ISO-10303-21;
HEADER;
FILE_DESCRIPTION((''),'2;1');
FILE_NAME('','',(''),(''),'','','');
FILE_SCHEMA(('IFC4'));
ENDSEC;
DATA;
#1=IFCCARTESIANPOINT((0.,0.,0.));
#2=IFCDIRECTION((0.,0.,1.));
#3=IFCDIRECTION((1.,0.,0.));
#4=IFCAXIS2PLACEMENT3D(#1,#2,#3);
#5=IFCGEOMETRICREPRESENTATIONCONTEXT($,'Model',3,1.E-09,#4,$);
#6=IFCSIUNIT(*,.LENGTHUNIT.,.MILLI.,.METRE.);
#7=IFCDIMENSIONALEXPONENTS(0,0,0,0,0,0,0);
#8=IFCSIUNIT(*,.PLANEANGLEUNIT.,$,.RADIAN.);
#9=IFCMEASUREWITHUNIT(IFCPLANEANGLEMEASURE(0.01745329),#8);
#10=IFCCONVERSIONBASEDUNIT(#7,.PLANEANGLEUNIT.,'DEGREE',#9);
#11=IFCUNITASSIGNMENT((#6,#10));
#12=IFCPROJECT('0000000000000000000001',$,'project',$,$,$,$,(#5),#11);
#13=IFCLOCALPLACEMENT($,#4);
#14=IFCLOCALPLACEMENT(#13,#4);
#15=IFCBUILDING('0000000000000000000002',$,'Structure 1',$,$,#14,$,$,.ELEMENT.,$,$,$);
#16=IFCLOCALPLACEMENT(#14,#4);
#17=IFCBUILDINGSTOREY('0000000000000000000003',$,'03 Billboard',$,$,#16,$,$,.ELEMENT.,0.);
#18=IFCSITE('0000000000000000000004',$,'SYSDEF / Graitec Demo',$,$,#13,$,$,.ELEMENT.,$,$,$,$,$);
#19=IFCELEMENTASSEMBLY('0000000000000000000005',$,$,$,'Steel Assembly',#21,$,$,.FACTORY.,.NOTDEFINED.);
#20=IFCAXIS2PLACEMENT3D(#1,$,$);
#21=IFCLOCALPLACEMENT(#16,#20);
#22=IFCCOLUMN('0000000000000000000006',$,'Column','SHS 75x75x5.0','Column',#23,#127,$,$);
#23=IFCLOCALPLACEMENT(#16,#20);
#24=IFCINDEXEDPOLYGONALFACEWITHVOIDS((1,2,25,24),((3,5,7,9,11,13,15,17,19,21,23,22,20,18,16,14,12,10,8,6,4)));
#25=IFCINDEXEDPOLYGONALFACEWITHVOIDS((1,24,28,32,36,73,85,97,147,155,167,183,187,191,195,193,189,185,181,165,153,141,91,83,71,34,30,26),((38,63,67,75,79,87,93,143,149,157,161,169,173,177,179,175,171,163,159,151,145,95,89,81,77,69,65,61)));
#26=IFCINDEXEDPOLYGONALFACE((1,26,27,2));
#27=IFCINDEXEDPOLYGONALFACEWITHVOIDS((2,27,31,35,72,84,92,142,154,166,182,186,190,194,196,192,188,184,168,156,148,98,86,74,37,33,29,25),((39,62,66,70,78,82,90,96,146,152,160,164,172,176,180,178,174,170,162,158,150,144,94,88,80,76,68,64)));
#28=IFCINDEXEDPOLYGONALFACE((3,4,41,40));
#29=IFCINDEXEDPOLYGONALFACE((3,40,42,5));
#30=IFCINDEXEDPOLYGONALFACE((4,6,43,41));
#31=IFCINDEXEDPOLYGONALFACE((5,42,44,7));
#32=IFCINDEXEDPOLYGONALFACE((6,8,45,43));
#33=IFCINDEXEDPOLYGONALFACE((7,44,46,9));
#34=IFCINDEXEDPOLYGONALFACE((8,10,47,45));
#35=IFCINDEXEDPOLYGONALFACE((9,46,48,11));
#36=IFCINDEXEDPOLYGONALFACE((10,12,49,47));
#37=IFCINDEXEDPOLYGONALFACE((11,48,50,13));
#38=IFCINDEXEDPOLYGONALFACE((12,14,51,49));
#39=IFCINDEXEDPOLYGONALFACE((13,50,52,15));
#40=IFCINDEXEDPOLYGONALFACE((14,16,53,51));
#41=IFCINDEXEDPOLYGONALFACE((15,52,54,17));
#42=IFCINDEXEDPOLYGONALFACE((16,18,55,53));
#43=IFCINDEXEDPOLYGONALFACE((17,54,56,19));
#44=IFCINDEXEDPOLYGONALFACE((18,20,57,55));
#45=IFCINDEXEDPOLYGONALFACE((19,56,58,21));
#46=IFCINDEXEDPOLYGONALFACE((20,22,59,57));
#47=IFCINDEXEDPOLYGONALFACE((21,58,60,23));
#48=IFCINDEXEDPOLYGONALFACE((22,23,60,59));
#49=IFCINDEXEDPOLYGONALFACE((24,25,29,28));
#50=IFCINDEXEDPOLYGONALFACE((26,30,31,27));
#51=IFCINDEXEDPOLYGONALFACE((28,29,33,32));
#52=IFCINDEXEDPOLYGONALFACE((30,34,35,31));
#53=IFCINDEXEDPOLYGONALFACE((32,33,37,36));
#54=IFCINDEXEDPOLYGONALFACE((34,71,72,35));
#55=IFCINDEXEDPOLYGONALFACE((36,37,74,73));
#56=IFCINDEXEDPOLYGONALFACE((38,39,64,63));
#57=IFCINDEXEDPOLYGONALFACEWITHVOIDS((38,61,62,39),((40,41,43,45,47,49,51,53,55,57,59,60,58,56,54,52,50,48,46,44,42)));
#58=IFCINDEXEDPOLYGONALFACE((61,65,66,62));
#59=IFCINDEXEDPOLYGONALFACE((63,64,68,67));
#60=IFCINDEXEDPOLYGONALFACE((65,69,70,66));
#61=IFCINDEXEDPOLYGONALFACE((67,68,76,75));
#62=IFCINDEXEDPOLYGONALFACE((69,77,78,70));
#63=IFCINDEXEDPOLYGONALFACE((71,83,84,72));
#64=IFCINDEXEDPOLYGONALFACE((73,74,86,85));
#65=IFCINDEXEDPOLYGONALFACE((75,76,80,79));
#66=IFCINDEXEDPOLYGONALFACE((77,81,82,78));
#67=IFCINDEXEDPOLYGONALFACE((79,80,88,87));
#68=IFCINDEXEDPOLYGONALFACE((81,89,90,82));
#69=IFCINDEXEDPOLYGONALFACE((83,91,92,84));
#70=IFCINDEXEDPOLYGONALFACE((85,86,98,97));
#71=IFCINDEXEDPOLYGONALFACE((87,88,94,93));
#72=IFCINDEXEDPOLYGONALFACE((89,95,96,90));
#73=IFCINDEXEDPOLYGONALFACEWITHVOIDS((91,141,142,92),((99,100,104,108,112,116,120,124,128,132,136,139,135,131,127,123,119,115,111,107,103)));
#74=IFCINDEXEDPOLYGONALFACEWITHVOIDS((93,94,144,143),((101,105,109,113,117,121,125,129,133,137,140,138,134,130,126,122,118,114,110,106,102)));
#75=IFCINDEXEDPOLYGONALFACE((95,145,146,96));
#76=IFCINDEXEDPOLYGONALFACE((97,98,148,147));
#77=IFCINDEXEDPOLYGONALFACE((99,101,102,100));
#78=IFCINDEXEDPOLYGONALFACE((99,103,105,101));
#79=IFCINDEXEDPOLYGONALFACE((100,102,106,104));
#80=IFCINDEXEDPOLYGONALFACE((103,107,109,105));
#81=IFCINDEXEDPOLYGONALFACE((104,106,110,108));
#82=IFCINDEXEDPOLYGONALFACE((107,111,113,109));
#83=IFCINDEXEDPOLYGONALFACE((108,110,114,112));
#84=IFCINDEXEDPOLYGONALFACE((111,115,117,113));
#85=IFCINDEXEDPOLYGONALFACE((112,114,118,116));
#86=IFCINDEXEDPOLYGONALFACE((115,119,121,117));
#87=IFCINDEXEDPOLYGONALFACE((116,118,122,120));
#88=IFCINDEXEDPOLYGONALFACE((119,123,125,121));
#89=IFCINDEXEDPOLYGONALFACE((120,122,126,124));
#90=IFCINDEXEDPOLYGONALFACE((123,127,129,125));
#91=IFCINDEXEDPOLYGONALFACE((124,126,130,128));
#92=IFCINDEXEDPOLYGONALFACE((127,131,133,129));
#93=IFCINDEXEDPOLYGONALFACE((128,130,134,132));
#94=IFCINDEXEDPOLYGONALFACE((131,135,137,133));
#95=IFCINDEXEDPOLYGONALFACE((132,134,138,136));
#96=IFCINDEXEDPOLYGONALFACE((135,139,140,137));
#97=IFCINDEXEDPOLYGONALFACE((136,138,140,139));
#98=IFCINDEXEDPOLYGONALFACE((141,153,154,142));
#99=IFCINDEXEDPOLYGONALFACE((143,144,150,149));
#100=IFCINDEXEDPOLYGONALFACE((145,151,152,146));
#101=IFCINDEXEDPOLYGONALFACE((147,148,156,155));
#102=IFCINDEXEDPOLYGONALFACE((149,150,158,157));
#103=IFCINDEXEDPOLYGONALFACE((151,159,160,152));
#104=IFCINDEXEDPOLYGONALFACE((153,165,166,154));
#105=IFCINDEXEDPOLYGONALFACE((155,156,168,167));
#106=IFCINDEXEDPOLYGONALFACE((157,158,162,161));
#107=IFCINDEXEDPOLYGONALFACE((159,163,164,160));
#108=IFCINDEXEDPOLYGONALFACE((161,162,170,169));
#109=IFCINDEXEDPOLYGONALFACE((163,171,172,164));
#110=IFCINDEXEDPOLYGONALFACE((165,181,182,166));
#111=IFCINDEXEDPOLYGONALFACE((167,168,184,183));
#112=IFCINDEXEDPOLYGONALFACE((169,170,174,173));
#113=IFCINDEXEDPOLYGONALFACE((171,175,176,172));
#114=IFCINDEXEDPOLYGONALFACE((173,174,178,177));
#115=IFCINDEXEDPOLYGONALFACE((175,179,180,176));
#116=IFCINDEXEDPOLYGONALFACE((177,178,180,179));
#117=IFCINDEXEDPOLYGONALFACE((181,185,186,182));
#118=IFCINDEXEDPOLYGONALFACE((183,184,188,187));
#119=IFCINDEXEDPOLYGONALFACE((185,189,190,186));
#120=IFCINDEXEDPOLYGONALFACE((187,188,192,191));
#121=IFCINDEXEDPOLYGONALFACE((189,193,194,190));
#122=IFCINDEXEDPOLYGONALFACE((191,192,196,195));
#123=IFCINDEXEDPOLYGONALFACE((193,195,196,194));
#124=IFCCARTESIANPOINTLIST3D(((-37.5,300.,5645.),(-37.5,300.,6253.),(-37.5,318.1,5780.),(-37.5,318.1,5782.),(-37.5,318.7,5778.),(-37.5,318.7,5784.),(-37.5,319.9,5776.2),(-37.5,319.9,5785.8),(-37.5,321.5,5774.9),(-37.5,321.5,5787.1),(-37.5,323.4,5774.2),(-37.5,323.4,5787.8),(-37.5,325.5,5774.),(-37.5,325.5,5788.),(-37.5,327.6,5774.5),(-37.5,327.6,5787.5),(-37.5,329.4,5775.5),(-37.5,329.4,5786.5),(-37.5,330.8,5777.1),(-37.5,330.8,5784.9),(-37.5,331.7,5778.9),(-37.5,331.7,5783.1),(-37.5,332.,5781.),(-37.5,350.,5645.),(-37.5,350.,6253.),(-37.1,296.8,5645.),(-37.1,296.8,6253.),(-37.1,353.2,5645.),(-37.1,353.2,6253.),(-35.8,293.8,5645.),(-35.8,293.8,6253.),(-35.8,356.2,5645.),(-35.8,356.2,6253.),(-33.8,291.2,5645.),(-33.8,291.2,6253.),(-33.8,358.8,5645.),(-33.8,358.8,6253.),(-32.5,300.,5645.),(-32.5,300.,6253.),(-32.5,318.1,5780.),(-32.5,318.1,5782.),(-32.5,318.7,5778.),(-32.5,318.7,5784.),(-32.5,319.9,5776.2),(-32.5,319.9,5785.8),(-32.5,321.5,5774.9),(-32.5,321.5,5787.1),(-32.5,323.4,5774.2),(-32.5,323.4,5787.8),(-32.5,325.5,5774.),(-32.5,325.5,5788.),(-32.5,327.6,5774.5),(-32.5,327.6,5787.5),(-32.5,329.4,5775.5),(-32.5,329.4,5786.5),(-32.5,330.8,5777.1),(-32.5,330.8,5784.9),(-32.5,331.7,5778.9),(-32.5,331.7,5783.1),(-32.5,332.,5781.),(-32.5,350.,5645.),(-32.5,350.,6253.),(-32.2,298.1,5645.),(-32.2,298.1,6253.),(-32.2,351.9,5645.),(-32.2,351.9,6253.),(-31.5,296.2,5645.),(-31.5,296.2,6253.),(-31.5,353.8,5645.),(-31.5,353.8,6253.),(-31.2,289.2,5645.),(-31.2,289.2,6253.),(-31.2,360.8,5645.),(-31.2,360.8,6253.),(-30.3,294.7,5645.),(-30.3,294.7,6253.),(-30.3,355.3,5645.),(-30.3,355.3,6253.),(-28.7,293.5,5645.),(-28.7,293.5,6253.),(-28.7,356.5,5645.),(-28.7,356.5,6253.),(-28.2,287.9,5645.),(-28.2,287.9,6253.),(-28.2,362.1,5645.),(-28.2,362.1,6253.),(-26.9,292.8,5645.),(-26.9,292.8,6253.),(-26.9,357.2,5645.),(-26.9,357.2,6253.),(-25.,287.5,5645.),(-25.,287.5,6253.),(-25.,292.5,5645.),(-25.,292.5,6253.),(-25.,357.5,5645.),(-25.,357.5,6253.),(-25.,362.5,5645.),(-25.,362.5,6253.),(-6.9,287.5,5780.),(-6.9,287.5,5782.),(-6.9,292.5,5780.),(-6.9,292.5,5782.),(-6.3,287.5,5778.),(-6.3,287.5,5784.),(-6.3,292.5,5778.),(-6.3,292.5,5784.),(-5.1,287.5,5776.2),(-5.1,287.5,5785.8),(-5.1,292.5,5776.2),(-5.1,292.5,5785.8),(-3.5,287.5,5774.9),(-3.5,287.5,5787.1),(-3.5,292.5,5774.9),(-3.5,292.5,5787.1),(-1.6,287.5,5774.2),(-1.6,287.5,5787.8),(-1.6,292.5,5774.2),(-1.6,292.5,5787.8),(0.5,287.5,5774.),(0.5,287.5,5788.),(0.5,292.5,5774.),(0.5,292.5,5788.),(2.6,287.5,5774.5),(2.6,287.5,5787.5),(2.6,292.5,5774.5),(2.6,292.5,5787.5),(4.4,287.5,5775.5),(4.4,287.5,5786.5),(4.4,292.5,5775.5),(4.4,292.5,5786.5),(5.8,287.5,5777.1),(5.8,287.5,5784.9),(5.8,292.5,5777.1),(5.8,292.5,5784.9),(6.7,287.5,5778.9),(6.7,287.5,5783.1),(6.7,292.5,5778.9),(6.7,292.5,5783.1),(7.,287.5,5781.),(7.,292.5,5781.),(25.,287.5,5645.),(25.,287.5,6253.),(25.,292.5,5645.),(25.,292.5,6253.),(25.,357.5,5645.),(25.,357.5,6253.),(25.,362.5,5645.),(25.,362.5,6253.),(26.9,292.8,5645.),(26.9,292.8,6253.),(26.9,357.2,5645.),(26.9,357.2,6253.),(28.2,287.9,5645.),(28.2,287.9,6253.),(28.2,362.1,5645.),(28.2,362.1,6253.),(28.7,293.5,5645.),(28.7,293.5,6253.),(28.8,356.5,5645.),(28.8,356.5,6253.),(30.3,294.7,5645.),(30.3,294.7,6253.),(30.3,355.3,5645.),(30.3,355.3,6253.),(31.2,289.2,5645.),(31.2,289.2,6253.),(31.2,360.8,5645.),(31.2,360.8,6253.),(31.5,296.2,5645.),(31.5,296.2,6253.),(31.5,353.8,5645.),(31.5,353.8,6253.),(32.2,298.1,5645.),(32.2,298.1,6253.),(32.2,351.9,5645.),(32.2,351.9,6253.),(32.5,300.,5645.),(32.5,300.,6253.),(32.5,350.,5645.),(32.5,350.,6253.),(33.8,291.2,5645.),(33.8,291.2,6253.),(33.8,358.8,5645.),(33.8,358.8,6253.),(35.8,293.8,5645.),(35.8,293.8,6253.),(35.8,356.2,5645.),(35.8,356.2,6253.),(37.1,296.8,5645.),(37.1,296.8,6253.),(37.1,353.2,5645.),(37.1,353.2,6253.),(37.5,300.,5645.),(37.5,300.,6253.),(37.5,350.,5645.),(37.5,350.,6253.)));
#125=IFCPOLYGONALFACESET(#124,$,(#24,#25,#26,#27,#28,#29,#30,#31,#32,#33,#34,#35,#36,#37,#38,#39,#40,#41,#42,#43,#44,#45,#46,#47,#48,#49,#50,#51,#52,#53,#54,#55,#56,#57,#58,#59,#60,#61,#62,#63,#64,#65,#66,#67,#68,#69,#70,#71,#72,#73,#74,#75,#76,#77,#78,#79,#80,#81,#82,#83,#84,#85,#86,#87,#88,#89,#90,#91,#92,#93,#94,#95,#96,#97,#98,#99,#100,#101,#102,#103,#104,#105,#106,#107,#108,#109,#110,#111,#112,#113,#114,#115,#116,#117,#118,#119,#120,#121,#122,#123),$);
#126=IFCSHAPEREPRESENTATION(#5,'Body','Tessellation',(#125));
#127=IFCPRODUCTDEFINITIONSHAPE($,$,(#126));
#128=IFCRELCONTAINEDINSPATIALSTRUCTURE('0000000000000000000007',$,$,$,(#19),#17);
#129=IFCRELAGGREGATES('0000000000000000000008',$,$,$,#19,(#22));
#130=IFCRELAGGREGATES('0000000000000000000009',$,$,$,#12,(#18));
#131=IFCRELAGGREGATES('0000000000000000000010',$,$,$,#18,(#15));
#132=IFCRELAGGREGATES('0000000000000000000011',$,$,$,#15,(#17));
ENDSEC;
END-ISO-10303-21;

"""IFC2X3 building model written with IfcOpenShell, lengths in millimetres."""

from ifc_helpers import new_model, entity, si_unit, converted_unit, frame, origin, origin_with_axes, origin_2d, origin_2d_with_axis, place, context, project, spatial, hollow_rectangle, circle, extrude, element, aggregate, save


model = new_model("IFC2X3")

# Units and contexts
model_context = context("Model", 3, precision=1e-09, world=origin_with_axes())
ifc_project = project(units=[si_unit("LENGTHUNIT", "METRE", prefix="MILLI"), converted_unit("PLANEANGLEUNIT", "DEGREE", entity("IfcPlaneAngleMeasure", 0.01745329), si_unit("PLANEANGLEUNIT", "RADIAN"), dimensions=[0, 0, 0, 0, 0, 0, 0])], contexts=[model_context])

# Site, building, storey
site_placement = place(None, origin_with_axes())
site = spatial("IfcSite", under=ifc_project, at=site_placement, Name="SYSDEF / Graitec Demo", CompositionType="ELEMENT")
building_placement = place(site_placement, origin_with_axes())
building = spatial("IfcBuilding", under=site, at=building_placement, Name="Structure 1", CompositionType="ELEMENT")
storey_placement = place(building_placement, origin_with_axes())
storey = spatial("IfcBuildingStorey", under=building, at=storey_placement, Name="03 Billboard", CompositionType="ELEMENT", Elevation=0.0)

# Element assembly, column, openings
assembly_1_placement = place(None, frame((0.0, 325.0, 6253.0), z_axis=(0.0, 0.0, 1.0), x_axis=(1.0, 0.0, 0.0)))
assembly_1 = element("IfcElementAssembly", 1, at=assembly_1_placement, inside=storey, ObjectType="Steel Assembly", AssemblyPlace="FACTORY", PredefinedType="NOTDEFINED")
column_placement = place(assembly_1_placement, origin_with_axes())
column = element("IfcColumn", 2, at=column_placement, Name="Column", Description="SHS 75x75x5.0", ObjectType="Column", context=model_context, shape_type="SweptSolid", body=[
    extrude(hollow_rectangle(XDim=75.0, YDim=75.0, WallThickness=5.0, InnerFilletRadius=7.5, OuterFilletRadius=12.5, at=origin_2d()), origin(), (0.0, 0.0, -1.0), 608.0),
])
opening_1_placement = place(column_placement, frame((0.0, -32.0, -472.0), z_axis=(0.0, -1.0, 0.0), x_axis=(1.0, 0.0, 0.0)))
element("IfcOpeningElement", 3, at=opening_1_placement, cuts=column, ObjectType="Opening", context=model_context, shape_type="SweptSolid", body=[
    extrude(circle(Radius=7.0, at=origin_2d_with_axis()), origin(), (0.0, 0.0, 1.0), 6.0),
])
opening_2_placement = place(column_placement, frame((-38.0, 0.0, -472.0), z_axis=(1.0, 0.0, 0.0), x_axis=(0.0, 1.0, 0.0)))
element("IfcOpeningElement", 4, at=opening_2_placement, cuts=column, ObjectType="Opening", context=model_context, shape_type="SweptSolid", body=[
    extrude(circle(Radius=7.0, at=origin_2d_with_axis()), origin(), (0.0, 0.0, 1.0), 6.0),
])
aggregate(assembly_1, [column])

save(model, "model.ifc")
